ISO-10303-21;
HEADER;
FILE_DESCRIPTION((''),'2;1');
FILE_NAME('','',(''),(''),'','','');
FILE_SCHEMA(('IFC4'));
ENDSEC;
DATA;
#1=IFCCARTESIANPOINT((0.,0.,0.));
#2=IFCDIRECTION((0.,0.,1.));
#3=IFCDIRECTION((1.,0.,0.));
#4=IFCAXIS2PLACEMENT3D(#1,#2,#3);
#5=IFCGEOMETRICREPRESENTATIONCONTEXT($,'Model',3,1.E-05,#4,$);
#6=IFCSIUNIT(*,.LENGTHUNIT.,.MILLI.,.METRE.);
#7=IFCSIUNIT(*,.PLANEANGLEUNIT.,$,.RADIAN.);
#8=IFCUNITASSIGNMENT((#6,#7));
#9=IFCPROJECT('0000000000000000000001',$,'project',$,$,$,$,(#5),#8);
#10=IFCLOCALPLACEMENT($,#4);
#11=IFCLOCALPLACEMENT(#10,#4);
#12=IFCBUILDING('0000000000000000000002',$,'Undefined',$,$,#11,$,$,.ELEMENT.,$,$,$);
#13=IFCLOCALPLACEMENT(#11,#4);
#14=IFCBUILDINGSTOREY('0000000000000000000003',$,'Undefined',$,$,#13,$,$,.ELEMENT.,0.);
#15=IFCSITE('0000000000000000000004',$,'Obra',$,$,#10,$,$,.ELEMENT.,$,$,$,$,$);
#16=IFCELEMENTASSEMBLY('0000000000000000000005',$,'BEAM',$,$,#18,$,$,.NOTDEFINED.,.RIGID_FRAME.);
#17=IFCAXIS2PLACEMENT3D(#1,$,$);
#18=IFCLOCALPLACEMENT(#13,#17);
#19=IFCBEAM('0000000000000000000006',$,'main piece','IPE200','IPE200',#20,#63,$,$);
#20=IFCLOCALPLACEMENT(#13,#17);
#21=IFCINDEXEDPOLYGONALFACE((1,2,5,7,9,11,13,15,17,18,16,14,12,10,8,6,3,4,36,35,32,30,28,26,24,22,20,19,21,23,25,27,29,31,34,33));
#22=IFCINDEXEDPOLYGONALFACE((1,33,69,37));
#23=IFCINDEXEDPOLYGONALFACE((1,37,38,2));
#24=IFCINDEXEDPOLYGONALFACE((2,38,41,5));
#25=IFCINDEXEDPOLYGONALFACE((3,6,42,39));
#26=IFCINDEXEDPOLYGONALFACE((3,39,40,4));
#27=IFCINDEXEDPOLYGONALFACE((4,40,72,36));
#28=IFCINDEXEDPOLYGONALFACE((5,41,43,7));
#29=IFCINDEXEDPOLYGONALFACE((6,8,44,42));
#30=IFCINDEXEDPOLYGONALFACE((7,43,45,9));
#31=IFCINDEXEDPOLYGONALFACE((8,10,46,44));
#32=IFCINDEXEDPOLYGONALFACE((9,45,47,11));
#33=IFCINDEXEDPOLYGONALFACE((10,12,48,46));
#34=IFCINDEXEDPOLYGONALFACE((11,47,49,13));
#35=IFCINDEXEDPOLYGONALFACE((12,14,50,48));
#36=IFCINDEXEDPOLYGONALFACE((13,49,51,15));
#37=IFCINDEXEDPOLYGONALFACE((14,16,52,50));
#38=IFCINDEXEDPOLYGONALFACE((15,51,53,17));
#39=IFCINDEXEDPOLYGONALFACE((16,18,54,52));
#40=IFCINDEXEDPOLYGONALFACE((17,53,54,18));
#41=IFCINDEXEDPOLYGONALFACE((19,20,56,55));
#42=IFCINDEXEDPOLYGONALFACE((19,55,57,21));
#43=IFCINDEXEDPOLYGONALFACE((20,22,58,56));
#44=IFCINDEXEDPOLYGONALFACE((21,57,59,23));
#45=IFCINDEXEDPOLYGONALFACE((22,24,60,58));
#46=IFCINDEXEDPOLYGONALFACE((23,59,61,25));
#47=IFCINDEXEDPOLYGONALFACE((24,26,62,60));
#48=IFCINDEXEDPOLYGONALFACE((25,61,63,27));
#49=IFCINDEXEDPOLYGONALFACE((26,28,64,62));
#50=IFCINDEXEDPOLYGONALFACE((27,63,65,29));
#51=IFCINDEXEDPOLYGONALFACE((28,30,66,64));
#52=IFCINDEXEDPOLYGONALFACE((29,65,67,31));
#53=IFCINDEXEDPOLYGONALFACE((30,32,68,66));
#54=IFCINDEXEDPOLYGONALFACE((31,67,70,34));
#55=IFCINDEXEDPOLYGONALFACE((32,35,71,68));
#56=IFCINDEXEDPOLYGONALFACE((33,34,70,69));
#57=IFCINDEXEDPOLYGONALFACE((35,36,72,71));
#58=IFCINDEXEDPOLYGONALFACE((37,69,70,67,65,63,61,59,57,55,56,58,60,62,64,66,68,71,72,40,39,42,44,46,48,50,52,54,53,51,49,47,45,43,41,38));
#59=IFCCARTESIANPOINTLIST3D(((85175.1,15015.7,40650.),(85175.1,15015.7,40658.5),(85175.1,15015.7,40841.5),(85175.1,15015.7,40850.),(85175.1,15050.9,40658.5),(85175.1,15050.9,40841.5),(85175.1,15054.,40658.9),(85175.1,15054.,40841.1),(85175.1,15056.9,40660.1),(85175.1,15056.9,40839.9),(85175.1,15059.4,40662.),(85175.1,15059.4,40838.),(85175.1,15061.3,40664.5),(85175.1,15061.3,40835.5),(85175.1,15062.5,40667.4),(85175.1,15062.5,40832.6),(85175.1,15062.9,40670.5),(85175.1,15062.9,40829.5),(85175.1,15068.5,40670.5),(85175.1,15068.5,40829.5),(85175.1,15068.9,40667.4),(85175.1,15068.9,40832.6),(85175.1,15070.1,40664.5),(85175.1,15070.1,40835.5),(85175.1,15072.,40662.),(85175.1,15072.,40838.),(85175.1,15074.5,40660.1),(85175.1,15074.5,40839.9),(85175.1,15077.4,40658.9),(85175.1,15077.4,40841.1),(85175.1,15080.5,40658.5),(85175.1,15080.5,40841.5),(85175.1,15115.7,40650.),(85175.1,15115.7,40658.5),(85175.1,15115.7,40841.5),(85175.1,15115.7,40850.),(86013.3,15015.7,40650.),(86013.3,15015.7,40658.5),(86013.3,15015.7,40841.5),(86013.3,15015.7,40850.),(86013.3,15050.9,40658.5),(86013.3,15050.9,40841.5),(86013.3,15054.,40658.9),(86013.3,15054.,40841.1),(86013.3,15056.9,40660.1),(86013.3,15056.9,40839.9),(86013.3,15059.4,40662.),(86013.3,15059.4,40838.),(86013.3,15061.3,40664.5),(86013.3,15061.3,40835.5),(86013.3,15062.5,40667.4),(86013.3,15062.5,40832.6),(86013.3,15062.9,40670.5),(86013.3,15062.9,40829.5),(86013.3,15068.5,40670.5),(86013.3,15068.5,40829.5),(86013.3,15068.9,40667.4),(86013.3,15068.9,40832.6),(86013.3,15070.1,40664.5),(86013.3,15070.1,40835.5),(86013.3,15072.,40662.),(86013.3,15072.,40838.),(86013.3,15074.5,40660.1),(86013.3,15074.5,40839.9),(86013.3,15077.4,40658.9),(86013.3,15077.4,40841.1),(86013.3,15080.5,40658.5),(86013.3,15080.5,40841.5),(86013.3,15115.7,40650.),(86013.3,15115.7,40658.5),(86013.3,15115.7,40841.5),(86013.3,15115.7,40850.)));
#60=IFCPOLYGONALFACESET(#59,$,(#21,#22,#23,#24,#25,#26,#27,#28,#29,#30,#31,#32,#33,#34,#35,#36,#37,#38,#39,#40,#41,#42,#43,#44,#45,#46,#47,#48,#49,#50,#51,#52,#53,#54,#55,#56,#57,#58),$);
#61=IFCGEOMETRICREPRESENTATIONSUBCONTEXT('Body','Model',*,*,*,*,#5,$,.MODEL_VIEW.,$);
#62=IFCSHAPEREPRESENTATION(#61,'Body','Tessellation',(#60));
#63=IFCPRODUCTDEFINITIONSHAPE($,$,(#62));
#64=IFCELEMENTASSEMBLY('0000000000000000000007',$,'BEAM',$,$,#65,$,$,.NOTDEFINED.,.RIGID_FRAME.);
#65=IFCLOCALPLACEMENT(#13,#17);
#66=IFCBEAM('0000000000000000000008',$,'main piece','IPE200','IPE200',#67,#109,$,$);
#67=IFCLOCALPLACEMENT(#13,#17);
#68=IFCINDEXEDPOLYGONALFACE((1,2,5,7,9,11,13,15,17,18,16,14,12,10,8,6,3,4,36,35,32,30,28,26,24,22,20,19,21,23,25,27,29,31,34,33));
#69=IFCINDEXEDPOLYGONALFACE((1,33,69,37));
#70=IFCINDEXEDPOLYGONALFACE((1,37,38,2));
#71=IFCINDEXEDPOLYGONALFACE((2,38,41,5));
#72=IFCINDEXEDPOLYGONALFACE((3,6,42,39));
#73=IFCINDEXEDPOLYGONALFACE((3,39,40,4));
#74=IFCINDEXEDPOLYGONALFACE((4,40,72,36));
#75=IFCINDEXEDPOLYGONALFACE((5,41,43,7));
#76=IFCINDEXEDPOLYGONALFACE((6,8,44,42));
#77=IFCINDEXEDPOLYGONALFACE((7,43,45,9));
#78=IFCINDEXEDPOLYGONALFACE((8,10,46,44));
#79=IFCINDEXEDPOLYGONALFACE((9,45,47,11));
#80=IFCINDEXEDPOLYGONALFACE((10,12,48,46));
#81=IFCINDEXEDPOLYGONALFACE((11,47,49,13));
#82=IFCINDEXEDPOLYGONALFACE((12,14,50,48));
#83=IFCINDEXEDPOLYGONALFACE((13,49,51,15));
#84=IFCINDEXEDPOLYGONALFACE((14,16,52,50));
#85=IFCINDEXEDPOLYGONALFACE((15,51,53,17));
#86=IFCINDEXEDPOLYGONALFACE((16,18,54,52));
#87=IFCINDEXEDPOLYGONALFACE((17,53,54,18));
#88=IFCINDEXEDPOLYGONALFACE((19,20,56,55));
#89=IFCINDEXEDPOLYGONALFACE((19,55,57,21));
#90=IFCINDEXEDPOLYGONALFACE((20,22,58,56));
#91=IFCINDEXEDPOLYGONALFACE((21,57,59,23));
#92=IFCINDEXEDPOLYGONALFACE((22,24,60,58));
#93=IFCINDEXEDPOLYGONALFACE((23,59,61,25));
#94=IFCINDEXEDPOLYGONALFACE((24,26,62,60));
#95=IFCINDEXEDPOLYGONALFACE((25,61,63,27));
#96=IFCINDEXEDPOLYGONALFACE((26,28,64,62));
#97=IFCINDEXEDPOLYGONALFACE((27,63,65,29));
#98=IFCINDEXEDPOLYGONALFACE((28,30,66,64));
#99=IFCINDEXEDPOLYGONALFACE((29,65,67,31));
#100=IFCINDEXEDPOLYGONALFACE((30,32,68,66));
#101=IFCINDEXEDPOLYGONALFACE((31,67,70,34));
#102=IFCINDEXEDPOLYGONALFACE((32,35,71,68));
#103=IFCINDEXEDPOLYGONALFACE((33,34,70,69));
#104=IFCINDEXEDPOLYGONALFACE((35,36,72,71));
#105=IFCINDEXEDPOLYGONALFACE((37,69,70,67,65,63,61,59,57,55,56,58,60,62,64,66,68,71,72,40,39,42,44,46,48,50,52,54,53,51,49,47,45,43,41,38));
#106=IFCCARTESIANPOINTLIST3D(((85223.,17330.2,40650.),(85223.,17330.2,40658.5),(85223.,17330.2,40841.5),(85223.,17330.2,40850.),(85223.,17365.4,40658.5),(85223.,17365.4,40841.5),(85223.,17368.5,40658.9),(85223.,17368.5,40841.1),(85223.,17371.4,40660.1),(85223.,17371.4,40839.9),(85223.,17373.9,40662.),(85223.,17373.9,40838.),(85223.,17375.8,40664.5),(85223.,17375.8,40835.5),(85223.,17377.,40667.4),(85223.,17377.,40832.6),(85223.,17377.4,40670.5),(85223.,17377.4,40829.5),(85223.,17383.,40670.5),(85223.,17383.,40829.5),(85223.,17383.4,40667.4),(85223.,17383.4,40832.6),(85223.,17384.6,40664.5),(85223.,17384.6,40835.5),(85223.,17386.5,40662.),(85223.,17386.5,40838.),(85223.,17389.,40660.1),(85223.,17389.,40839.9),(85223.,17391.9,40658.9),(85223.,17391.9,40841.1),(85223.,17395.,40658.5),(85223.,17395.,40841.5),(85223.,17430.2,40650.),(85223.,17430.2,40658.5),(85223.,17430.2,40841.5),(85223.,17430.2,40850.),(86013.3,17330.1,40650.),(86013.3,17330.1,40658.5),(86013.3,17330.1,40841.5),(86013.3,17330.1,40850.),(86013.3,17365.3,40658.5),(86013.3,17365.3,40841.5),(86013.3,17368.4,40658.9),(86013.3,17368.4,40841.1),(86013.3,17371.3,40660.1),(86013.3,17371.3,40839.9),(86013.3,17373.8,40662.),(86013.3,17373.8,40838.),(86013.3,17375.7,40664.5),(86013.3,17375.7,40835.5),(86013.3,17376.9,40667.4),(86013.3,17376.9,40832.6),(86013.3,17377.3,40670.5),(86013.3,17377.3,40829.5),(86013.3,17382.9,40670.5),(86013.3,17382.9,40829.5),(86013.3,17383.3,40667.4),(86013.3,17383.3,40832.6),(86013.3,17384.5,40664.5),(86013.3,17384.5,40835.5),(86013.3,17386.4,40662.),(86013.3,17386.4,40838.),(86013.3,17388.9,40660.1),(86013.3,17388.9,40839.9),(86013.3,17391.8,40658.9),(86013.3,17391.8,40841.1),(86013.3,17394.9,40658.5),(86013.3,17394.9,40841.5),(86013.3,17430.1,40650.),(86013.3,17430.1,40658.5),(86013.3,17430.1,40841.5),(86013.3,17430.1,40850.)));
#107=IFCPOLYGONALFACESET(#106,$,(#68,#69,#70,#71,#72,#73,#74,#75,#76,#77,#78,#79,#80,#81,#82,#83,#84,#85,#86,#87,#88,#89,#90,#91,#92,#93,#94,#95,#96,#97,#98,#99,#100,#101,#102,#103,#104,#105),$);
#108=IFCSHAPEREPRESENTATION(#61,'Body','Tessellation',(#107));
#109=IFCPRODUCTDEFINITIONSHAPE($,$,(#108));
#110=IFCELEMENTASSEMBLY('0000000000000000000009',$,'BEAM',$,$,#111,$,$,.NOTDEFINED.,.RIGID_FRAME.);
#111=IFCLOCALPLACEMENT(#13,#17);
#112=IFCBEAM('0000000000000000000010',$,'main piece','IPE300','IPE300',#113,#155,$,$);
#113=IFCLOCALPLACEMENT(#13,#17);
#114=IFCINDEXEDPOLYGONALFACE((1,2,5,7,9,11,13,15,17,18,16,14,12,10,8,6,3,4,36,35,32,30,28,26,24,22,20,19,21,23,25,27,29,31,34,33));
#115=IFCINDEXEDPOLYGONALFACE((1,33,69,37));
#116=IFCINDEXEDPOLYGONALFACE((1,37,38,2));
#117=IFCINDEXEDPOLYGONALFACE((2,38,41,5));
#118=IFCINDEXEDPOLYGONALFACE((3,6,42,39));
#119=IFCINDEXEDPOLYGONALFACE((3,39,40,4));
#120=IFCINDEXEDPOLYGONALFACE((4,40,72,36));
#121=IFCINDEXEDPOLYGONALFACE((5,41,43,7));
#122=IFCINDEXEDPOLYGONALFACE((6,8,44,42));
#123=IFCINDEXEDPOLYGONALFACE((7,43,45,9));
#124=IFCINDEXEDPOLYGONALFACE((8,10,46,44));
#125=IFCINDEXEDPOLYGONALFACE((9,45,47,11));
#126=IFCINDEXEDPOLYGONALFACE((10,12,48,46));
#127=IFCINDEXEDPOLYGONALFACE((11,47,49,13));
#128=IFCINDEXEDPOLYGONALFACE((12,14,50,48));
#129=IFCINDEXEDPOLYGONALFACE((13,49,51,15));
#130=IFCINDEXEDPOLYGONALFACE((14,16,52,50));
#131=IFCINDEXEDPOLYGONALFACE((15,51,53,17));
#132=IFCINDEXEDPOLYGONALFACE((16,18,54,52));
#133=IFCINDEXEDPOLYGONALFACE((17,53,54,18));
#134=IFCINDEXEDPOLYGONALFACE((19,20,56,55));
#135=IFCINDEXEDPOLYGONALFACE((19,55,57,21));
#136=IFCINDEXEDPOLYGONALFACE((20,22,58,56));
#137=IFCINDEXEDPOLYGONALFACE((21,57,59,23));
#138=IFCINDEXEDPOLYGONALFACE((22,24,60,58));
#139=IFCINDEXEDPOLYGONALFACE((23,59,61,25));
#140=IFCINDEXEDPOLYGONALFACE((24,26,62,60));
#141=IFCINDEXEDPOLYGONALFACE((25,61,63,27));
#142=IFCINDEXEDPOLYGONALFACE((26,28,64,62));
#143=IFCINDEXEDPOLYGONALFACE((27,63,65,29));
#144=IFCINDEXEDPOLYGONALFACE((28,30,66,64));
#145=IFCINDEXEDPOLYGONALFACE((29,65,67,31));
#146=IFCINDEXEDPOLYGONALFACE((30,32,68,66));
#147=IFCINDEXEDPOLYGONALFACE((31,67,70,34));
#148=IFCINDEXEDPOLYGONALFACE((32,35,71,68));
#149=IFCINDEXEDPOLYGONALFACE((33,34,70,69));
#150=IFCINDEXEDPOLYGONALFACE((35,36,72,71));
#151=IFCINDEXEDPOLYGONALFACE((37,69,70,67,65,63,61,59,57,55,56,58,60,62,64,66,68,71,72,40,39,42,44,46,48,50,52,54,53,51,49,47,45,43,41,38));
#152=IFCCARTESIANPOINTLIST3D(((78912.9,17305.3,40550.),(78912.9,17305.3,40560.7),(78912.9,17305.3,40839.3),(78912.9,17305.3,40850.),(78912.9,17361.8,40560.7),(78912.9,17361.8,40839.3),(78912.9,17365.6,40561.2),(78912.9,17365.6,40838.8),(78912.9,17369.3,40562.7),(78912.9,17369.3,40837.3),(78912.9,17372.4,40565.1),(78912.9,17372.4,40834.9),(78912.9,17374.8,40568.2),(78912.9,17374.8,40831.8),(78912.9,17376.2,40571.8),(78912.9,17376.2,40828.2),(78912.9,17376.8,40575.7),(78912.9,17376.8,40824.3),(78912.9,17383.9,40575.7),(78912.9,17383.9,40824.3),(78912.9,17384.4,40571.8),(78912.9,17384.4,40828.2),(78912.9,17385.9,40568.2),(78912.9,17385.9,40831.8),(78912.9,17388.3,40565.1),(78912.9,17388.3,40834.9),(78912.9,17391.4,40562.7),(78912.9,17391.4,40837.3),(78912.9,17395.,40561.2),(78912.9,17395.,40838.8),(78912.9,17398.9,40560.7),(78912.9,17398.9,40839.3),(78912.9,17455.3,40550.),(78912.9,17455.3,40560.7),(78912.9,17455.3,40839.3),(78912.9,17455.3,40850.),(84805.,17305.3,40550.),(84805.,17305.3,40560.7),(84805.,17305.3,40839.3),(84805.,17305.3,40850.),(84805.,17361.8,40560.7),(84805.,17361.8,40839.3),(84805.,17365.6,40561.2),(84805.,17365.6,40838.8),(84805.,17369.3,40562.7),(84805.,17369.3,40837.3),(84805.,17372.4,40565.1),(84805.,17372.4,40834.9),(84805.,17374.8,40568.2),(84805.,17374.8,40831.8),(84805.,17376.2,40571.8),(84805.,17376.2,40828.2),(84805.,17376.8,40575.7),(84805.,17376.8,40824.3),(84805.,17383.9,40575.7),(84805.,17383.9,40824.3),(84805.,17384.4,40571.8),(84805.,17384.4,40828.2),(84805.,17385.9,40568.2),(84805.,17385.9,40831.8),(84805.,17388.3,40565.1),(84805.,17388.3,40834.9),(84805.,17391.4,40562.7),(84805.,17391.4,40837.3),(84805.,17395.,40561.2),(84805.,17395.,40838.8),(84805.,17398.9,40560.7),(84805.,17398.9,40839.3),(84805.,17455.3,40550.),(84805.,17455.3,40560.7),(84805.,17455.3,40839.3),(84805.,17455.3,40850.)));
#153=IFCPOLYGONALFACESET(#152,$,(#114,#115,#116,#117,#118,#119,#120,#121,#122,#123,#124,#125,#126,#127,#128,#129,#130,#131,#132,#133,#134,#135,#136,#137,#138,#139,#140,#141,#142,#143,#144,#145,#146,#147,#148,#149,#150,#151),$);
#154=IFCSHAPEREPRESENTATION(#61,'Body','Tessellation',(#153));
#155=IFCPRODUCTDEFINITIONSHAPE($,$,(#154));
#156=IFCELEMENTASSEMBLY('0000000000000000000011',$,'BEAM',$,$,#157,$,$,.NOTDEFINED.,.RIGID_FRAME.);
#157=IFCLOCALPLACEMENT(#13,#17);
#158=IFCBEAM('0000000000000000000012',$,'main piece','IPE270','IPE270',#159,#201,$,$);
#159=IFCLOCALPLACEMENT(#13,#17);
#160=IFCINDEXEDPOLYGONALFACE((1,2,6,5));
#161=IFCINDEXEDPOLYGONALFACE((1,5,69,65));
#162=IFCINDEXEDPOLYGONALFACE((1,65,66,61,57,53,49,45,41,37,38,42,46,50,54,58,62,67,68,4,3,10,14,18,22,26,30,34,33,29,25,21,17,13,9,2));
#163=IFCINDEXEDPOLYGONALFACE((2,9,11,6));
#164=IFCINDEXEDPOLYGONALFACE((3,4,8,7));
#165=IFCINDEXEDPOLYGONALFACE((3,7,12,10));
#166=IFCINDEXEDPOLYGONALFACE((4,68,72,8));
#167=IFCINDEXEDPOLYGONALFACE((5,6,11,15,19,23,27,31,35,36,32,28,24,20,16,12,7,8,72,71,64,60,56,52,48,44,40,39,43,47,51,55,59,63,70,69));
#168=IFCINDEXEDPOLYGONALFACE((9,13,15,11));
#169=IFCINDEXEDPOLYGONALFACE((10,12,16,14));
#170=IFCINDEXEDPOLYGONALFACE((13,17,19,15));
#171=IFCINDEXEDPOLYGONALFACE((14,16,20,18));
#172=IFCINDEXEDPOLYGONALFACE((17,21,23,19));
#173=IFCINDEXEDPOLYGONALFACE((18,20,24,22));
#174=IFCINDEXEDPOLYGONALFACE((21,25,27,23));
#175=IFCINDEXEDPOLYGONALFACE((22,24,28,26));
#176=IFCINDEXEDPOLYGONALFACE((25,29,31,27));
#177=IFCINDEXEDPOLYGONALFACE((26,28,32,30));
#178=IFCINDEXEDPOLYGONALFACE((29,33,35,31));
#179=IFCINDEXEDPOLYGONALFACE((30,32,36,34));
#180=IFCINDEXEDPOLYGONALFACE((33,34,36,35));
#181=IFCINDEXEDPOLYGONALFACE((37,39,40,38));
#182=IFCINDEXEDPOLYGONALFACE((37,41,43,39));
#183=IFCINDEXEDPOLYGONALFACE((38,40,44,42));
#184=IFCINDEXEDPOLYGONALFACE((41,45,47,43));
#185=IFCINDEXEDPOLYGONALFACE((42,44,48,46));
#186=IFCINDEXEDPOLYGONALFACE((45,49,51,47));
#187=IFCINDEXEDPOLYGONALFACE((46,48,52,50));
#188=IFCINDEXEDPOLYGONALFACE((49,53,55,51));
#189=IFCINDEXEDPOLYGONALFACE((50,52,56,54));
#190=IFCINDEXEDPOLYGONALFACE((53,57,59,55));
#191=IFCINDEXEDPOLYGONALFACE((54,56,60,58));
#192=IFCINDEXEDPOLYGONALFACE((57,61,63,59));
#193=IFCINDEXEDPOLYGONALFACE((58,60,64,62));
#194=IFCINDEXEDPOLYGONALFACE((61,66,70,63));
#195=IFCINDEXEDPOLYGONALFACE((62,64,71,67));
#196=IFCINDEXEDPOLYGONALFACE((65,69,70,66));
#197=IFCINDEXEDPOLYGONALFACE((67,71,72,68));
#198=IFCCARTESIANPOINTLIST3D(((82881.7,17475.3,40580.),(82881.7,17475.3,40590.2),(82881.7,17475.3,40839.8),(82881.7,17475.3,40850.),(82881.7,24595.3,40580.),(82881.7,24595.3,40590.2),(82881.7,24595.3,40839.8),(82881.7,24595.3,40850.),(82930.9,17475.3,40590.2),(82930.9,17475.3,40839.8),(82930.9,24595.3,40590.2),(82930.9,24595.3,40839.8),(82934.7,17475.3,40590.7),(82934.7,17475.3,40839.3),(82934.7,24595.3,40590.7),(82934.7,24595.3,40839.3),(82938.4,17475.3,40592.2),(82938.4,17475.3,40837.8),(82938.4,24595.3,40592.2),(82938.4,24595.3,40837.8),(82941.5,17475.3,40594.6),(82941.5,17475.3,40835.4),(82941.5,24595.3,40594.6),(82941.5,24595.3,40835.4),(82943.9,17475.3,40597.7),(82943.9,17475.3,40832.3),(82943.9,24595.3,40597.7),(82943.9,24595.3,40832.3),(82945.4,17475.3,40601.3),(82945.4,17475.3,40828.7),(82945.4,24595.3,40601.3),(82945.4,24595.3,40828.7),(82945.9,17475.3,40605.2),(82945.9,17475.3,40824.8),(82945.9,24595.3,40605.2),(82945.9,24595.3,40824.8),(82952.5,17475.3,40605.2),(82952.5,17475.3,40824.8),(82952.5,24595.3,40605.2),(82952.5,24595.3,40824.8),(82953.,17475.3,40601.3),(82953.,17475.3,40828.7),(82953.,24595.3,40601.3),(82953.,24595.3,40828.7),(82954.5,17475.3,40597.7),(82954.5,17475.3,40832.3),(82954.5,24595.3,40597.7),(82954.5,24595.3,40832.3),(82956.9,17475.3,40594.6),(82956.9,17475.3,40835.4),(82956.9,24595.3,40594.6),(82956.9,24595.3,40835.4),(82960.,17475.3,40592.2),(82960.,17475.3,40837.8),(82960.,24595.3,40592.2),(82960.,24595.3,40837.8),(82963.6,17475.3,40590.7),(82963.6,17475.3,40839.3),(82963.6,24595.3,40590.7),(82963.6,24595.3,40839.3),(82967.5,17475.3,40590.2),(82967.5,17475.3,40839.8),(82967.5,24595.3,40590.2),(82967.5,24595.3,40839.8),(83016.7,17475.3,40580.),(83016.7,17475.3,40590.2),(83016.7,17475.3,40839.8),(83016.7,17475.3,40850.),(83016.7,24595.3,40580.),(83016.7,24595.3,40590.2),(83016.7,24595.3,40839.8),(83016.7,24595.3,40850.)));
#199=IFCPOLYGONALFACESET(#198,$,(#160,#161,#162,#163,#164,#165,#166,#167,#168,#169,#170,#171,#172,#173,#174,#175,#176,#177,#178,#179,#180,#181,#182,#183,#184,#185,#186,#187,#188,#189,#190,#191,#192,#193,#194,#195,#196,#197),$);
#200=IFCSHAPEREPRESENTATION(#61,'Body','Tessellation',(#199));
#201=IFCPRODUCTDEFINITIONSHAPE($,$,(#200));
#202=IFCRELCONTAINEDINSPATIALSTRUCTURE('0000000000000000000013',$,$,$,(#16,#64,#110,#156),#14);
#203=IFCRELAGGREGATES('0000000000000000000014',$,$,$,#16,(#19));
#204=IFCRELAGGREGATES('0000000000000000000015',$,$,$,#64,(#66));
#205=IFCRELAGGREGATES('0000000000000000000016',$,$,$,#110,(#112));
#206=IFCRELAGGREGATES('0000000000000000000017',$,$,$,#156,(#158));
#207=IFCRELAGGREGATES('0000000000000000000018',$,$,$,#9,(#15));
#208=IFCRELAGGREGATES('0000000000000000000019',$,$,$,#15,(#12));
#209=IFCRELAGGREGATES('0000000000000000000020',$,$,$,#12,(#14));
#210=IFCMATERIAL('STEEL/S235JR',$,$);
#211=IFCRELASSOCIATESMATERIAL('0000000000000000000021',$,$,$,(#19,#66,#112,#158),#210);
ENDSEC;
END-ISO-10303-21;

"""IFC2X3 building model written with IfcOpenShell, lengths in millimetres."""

from ifc_helpers import new_model, si_unit, frame, origin_with_axes, origin_2d_with_axis, place, context, subcontext, project, spatial, i_section, extrude, material, element, aggregate, save


model = new_model("IFC2X3")

# Units and contexts
model_context = context("Model", 3, precision=1e-05, world=origin_with_axes())
body_context = subcontext(model_context, "Body", "Model", "MODEL_VIEW")
ifc_project = project(units=[si_unit("LENGTHUNIT", "METRE", prefix="MILLI"), si_unit("PLANEANGLEUNIT", "RADIAN")], contexts=[model_context])

# Site, building, storey
site_placement = place(None, origin_with_axes())
site = spatial("IfcSite", under=ifc_project, at=site_placement, Name="Obra", CompositionType="ELEMENT")
building_placement = place(site_placement, origin_with_axes())
building = spatial("IfcBuilding", under=site, at=building_placement, Name="Undefined", CompositionType="ELEMENT")
storey_placement = place(building_placement, origin_with_axes())
storey = spatial("IfcBuildingStorey", under=building, at=storey_placement, Name="Undefined", CompositionType="ELEMENT", Elevation=0.0)

# Element assemblies, beams
ifc_material_1 = material(Name="STEEL/S235JR")
assembly_1_placement = place(storey_placement, origin_with_axes())
assembly_1 = element("IfcElementAssembly", 1, at=assembly_1_placement, inside=storey, Name="BEAM", AssemblyPlace="NOTDEFINED", PredefinedType="RIGID_FRAME")
beam_1_placement = place(assembly_1_placement, frame((85175.1, 15065.7, 40750.0), z_axis=(0.0, 0.0, 1.0), x_axis=(1.0, 0.0, 0.0)))
beam_1 = element("IfcBeam", 2, at=beam_1_placement, material=ifc_material_1, Name="main piece", Description="IPE200", ObjectType="IPE200", context=body_context, shape_type="SweptSolid", body=[
    extrude(i_section(OverallWidth=100.0, OverallDepth=200.0, WebThickness=5.6, FlangeThickness=8.5, FilletRadius=12.0, at=origin_2d_with_axis()), frame((838.2, 0.0, 0.0), z_axis=(-1.0, 0.0, 0.0), x_axis=(0.0, -1.0, 0.0)), (0.0, 0.0, 1.0), 838.2),
])
aggregate(assembly_1, [beam_1])
assembly_2_placement = place(storey_placement, origin_with_axes())
assembly_2 = element("IfcElementAssembly", 3, at=assembly_2_placement, inside=storey, Name="BEAM", AssemblyPlace="NOTDEFINED", PredefinedType="RIGID_FRAME")
beam_2_placement = place(assembly_2_placement, frame((85223.0, 17380.2, 40750.0), z_axis=(0.0, 0.0, 1.0), x_axis=(1.0, -0.000094, 0.0)))
beam_2 = element("IfcBeam", 4, at=beam_2_placement, material=ifc_material_1, Name="main piece", Description="IPE200", ObjectType="IPE200", context=body_context, shape_type="SweptSolid", body=[
    extrude(i_section(OverallWidth=100.0, OverallDepth=200.0, WebThickness=5.6, FlangeThickness=8.5, FilletRadius=12.0, at=origin_2d_with_axis()), frame((790.3, 0.0, 0.0), z_axis=(-1.0, 0.0, 0.0), x_axis=(0.0, -1.0, 0.0)), (0.0, 0.0, 1.0), 790.3),
])
aggregate(assembly_2, [beam_2])
assembly_3_placement = place(storey_placement, origin_with_axes())
assembly_3 = element("IfcElementAssembly", 5, at=assembly_3_placement, inside=storey, Name="BEAM", AssemblyPlace="NOTDEFINED", PredefinedType="RIGID_FRAME")
beam_3_placement = place(assembly_3_placement, frame((78912.9, 17380.3, 40700.0), z_axis=(0.0, 0.0, 1.0), x_axis=(1.0, 0.0, 0.0)))
beam_3 = element("IfcBeam", 6, at=beam_3_placement, material=ifc_material_1, Name="main piece", Description="IPE300", ObjectType="IPE300", context=body_context, shape_type="SweptSolid", body=[
    extrude(i_section(OverallWidth=150.0, OverallDepth=300.0, WebThickness=7.1, FlangeThickness=10.7, FilletRadius=15.0, at=origin_2d_with_axis()), frame((5892.1, 0.0, 0.0), z_axis=(-1.0, 0.0, 0.0), x_axis=(0.0, -1.0, 0.0)), (0.0, 0.0, 1.0), 5892.1),
])
aggregate(assembly_3, [beam_3])
assembly_4_placement = place(storey_placement, origin_with_axes())
assembly_4 = element("IfcElementAssembly", 7, at=assembly_4_placement, inside=storey, Name="BEAM", AssemblyPlace="NOTDEFINED", PredefinedType="RIGID_FRAME")
beam_4_placement = place(assembly_4_placement, frame((82949.2, 17475.3, 40715.0), z_axis=(0.0, 0.0, 1.0), x_axis=(0.0, 1.0, 0.0)))
beam_4 = element("IfcBeam", 8, at=beam_4_placement, material=ifc_material_1, Name="main piece", Description="IPE270", ObjectType="IPE270", context=body_context, shape_type="SweptSolid", body=[
    extrude(i_section(OverallWidth=135.0, OverallDepth=270.0, WebThickness=6.6, FlangeThickness=10.2, FilletRadius=15.0, at=origin_2d_with_axis()), frame((7120.0, 0.0, 0.0), z_axis=(-1.0, 0.0, 0.0), x_axis=(0.0, -1.0, 0.0)), (0.0, 0.0, 1.0), 7120.0),
])
aggregate(assembly_4, [beam_4])

save(model, "model.ifc")
